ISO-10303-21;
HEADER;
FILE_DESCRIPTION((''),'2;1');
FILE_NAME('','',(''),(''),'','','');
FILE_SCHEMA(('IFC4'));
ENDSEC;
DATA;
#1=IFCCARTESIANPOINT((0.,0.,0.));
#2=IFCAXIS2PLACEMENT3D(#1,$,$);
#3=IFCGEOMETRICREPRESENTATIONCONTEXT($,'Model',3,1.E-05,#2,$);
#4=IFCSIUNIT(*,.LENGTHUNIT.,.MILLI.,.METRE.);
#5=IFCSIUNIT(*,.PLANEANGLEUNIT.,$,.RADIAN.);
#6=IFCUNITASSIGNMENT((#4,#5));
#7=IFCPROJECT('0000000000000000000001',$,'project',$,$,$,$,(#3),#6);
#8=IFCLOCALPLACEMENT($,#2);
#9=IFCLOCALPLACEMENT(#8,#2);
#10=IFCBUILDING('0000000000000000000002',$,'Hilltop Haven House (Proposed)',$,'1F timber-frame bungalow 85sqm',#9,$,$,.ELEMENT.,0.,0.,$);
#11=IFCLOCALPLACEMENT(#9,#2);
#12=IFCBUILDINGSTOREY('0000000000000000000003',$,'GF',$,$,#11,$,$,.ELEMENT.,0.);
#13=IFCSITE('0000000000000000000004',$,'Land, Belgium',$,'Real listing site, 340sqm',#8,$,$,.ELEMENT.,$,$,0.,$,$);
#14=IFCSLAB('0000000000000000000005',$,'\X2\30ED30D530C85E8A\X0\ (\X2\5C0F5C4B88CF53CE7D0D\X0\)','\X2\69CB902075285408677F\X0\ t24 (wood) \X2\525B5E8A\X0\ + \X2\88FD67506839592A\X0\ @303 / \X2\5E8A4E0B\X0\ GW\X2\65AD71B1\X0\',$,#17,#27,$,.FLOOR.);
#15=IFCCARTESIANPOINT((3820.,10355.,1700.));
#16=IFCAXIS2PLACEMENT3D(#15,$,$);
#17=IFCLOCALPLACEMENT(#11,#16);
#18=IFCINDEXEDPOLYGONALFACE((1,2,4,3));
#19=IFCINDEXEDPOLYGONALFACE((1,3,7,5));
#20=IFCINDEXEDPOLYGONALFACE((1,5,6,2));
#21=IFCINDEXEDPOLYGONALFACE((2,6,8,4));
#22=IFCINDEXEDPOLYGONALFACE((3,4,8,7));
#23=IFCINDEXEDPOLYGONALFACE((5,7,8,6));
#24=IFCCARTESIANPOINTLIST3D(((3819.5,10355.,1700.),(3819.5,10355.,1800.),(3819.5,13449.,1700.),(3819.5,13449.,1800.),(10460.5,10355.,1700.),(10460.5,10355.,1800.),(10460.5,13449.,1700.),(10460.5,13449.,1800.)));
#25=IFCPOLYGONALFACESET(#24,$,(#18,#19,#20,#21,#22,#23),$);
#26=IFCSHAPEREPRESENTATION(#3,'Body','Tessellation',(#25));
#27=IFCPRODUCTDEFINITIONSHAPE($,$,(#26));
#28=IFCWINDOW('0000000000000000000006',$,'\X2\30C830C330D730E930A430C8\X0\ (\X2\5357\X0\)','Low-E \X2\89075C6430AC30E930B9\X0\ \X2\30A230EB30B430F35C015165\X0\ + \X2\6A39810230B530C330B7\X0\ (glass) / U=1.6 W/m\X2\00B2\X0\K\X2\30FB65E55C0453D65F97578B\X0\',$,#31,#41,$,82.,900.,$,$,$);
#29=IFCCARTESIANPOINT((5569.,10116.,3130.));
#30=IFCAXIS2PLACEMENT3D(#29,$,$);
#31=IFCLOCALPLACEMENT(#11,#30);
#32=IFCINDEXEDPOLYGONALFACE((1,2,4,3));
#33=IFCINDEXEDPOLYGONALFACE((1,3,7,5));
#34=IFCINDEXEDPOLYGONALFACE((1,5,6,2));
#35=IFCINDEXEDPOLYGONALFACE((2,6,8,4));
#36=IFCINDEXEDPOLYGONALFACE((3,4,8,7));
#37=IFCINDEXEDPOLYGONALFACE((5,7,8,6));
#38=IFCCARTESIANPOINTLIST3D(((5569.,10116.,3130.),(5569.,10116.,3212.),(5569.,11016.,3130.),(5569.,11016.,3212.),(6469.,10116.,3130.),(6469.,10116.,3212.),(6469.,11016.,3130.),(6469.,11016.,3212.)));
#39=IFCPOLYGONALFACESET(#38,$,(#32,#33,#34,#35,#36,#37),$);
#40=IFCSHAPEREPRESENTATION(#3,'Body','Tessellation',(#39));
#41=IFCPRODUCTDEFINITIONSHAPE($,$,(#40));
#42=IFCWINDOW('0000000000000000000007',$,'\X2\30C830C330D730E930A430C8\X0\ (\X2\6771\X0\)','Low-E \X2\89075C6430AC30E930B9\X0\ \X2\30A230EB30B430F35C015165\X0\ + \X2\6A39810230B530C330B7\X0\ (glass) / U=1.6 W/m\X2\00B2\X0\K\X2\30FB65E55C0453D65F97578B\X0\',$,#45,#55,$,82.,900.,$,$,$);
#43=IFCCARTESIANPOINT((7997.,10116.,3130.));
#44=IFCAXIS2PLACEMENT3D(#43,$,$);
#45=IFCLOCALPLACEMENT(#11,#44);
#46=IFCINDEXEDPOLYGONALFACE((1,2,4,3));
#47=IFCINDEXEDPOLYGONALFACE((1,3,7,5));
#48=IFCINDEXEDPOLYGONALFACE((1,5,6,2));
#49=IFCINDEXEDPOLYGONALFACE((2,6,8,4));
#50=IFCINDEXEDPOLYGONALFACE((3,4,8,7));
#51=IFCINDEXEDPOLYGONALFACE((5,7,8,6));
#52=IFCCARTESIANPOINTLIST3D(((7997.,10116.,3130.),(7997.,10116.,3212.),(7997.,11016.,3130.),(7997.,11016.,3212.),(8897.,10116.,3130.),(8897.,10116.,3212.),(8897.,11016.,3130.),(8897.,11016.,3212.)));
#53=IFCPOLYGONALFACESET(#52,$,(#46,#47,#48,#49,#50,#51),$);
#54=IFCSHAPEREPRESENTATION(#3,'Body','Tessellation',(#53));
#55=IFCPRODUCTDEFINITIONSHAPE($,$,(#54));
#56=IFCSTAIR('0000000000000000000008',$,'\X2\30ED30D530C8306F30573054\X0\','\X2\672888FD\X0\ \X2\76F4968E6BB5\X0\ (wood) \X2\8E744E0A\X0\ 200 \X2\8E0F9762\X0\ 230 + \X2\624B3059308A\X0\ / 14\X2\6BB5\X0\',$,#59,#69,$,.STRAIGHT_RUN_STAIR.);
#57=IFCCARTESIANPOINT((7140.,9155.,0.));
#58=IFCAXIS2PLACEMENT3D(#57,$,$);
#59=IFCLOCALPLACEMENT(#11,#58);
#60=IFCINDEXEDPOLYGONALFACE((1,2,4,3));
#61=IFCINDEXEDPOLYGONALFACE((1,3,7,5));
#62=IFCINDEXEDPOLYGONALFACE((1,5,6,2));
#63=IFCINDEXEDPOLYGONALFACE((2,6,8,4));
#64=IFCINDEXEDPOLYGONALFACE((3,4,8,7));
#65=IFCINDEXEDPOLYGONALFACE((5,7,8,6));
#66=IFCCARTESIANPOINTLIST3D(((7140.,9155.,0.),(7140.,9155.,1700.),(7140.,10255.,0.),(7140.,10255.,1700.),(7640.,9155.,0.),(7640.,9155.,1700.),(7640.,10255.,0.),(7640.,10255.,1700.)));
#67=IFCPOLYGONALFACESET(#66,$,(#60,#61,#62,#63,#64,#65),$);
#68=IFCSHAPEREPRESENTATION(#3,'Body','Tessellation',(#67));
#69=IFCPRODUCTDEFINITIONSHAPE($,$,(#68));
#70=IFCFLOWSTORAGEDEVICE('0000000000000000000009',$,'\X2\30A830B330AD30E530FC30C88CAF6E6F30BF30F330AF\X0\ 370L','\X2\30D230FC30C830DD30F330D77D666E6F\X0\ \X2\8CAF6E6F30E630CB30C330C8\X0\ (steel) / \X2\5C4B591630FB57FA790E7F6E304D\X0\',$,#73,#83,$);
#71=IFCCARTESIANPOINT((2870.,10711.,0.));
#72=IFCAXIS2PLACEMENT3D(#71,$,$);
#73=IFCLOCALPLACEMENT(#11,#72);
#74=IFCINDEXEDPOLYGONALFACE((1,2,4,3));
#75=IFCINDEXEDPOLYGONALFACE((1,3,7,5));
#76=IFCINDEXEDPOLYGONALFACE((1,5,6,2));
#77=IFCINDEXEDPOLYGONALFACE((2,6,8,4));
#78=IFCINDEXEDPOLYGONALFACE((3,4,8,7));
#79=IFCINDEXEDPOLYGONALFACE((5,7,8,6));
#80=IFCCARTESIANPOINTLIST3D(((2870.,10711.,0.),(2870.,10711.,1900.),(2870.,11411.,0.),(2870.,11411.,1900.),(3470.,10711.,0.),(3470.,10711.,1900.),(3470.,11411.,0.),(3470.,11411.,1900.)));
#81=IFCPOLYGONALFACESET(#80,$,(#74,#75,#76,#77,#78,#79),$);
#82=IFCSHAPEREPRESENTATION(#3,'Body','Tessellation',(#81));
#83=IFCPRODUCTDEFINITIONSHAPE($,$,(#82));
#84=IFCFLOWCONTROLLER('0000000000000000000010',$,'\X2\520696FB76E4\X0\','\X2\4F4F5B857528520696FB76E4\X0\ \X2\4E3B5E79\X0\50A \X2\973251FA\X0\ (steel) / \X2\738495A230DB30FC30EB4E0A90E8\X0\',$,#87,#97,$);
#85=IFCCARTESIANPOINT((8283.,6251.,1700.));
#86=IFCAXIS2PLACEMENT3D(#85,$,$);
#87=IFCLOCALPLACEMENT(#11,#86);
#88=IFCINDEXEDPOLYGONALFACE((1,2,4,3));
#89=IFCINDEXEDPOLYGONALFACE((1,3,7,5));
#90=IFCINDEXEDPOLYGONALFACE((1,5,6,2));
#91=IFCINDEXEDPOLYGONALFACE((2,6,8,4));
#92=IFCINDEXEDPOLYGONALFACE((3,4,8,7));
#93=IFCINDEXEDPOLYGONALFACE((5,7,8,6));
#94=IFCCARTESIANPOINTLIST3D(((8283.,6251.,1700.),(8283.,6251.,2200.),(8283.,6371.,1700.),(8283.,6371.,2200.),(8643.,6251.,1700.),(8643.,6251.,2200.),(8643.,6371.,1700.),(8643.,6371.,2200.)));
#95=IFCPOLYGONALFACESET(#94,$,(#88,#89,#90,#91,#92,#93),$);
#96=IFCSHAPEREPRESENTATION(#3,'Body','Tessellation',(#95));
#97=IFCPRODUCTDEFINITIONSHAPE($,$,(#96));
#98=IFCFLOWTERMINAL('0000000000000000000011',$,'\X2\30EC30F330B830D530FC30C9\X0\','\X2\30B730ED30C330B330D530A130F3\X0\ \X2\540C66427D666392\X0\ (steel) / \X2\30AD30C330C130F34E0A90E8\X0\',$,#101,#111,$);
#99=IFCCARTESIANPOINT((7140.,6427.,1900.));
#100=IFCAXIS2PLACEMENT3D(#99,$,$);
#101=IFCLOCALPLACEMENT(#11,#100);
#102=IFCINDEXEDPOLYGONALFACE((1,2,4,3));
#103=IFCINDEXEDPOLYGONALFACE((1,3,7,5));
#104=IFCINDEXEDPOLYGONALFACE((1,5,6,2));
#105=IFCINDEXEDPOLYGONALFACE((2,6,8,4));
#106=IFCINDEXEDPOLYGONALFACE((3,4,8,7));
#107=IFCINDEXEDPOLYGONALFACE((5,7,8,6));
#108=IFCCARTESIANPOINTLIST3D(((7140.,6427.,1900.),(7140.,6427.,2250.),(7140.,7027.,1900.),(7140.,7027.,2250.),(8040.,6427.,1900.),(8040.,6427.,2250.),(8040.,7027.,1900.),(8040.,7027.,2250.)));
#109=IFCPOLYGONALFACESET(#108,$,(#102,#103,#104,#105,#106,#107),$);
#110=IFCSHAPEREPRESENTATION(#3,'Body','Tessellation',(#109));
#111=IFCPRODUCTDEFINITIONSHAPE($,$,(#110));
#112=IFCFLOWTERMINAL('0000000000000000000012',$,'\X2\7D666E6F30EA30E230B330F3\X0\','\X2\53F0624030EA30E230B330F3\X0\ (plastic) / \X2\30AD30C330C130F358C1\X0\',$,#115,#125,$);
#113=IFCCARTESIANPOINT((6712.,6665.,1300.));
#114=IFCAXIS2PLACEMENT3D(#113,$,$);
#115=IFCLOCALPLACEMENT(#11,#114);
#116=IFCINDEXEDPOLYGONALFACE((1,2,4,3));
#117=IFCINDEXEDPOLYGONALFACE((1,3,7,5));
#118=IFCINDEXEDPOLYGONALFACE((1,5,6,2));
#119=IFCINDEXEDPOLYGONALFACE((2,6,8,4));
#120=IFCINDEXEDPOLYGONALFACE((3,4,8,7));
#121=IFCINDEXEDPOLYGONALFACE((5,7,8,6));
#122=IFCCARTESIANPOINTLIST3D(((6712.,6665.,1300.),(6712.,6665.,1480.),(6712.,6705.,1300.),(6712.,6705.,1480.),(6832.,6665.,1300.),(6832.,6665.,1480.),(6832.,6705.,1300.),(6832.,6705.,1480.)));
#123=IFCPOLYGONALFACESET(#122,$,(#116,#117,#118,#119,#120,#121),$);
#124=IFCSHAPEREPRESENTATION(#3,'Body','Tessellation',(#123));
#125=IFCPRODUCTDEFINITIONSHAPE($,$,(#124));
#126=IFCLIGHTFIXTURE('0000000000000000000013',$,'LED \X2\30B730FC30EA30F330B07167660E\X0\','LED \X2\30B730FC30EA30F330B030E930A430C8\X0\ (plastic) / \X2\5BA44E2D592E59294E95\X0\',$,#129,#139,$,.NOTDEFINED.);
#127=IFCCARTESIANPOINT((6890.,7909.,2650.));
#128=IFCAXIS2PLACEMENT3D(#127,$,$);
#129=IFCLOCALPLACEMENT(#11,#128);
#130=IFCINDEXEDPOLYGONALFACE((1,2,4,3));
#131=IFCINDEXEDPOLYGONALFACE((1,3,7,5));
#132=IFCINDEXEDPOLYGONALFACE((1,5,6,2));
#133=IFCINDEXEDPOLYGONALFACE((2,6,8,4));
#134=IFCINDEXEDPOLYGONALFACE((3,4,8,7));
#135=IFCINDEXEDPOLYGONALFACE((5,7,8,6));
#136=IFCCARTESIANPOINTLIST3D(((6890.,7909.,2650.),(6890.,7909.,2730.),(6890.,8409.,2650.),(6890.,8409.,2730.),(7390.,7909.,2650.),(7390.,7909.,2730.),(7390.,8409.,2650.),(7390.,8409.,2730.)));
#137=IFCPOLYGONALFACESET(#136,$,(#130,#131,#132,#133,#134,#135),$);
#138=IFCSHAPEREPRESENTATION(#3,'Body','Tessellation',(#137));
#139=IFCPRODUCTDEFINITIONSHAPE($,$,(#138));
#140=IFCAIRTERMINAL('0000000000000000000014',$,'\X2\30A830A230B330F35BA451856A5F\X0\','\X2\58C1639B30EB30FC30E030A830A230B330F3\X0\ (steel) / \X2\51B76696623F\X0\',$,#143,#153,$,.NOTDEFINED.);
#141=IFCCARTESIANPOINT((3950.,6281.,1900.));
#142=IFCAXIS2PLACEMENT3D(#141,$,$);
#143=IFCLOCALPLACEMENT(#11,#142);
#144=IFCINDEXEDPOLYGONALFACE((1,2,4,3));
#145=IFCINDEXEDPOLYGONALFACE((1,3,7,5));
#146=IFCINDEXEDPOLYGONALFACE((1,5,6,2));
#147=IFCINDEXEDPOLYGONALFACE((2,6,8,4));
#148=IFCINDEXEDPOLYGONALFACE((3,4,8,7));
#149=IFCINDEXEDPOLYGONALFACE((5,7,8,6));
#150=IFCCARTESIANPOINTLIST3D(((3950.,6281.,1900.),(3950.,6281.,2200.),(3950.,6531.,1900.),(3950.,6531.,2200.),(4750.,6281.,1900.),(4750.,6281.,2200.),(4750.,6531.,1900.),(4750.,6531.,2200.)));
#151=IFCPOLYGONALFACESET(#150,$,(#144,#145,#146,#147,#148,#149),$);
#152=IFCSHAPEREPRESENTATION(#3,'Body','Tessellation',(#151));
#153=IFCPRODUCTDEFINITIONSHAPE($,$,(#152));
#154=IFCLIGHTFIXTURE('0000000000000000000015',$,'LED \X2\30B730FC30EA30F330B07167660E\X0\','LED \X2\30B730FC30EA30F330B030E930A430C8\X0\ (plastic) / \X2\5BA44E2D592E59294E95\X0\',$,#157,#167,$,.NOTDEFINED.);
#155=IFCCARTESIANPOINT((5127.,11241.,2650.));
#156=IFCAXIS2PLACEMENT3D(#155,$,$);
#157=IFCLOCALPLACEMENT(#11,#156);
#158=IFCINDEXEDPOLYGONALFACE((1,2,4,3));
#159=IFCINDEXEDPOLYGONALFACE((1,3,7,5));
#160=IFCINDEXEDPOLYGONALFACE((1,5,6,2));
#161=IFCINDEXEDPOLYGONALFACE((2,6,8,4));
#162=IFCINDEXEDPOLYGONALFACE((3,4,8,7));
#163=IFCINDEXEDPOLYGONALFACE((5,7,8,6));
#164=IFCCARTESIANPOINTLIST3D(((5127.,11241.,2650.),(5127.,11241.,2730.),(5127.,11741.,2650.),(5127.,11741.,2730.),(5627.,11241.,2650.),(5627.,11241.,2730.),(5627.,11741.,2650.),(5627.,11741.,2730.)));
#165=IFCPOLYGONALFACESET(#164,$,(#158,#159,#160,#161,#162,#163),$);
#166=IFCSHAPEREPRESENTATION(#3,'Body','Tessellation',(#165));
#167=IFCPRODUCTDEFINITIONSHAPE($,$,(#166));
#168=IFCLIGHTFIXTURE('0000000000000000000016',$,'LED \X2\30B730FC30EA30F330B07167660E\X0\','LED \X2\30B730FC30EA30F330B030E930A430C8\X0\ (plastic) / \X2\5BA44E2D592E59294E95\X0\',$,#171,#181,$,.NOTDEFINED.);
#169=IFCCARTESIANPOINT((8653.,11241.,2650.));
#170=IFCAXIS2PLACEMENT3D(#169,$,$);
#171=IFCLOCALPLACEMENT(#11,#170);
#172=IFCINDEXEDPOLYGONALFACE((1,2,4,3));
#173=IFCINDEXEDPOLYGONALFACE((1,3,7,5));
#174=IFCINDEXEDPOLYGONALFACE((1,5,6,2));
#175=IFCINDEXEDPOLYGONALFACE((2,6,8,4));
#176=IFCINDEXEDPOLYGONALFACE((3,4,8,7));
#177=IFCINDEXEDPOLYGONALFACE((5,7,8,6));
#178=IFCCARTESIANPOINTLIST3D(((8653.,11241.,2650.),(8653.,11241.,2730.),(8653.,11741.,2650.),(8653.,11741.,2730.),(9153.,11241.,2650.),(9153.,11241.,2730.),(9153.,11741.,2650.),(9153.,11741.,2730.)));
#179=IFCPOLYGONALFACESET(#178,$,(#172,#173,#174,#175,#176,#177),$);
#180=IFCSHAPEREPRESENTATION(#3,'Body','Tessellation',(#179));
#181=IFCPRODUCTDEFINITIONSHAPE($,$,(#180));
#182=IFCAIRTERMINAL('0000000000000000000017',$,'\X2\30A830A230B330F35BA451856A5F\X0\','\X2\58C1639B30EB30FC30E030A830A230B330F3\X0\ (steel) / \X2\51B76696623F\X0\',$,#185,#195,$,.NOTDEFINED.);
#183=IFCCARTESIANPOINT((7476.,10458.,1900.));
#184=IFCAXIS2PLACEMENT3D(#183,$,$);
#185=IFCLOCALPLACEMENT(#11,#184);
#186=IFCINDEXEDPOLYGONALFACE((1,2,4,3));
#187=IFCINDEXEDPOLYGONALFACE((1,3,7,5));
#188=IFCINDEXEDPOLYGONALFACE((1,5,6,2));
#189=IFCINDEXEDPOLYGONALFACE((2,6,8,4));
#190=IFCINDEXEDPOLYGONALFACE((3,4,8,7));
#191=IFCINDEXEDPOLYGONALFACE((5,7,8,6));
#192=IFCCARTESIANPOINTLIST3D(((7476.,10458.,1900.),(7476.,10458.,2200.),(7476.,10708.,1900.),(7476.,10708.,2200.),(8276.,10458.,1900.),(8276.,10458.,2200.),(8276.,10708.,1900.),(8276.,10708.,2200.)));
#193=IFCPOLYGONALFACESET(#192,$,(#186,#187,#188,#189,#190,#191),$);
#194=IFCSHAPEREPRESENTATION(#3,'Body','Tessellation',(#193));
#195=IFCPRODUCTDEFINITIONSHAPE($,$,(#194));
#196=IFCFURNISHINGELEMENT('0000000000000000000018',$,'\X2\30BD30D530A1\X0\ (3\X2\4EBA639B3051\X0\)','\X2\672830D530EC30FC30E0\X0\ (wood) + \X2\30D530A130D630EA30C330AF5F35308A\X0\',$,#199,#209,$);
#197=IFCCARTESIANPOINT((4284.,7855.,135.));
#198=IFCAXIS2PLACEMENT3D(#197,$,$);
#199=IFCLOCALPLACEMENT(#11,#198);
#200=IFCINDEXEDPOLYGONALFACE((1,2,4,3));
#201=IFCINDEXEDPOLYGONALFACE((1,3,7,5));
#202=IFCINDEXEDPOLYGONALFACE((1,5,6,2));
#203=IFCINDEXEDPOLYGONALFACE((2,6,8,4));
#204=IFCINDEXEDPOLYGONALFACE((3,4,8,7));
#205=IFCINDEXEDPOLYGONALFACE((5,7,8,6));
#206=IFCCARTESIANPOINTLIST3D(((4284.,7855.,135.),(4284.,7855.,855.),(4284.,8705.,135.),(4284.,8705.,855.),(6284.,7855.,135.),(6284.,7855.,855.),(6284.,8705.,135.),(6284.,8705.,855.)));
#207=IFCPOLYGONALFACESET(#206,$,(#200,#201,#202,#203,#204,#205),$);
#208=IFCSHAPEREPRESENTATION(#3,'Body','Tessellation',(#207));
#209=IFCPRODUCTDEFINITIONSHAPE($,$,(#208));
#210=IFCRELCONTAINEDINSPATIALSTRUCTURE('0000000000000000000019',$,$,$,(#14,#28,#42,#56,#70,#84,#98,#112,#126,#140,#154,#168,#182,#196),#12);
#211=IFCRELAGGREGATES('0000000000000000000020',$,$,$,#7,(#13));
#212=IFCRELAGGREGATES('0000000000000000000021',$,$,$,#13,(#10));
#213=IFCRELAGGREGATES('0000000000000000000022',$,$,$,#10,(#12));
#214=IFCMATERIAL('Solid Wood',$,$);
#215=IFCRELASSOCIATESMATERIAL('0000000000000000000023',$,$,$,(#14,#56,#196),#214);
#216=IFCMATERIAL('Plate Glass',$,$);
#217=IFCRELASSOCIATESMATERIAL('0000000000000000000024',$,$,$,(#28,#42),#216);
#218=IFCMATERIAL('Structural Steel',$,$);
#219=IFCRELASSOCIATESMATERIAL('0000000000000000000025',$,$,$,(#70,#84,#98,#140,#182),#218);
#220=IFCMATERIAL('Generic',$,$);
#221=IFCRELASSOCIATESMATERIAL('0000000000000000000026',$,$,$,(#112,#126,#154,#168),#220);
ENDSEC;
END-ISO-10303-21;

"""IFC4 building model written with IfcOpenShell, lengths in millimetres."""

from ifc_helpers import new_model, si_unit, frame, frame_2d, origin, place, context, project, spatial, rectangle, extrude, material, element, save


model = new_model("IFC4")

# Units and contexts
model_context = context("Model", 3, precision=1e-05, world=origin())
ifc_project = project(units=[si_unit("LENGTHUNIT", "METRE", prefix="MILLI"), si_unit("PLANEANGLEUNIT", "RADIAN")], contexts=[model_context])

# Site, building, storey
site_placement = place(None, origin())
site = spatial("IfcSite", under=ifc_project, at=site_placement, Name="Land, Belgium", ObjectType="Real listing site, 340sqm", CompositionType="ELEMENT", RefElevation=0.0)
building_placement = place(site_placement, origin())
building = spatial("IfcBuilding", under=site, at=building_placement, Name="Hilltop Haven House (Proposed)", ObjectType="1F timber-frame bungalow 85sqm", CompositionType="ELEMENT", ElevationOfRefHeight=0.0, ElevationOfTerrain=0.0)
storey_placement = place(building_placement, origin())
storey = spatial("IfcBuildingStorey", under=building, at=storey_placement, Name="GF", CompositionType="ELEMENT", Elevation=0.0)

# Shared definitions
ifc_material_1 = material(Name="Solid Wood")

# Slab
slab_placement = place(storey_placement, frame((3820.0, 10355.0, 1700.0)))
element("IfcSlab", 1, at=slab_placement, inside=storey, material=ifc_material_1, Name="ロフト床 (小屋裏収納)", Description="構造用合板 t24 (wood) 剛床 + 製材根太 @303 / 床下 GW断熱", PredefinedType="FLOOR", context=model_context, shape_type="SweptSolid", body=[
    extrude(rectangle(XDim=6641.0, YDim=3094.0, at=frame_2d((3320.0, 1547.0))), frame((3820.0, 10355.0, 1700.0)), (0.0, 0.0, 1.0), 100.0),
])

# Windows
ifc_material_2 = material(Name="Plate Glass")
window_1_placement = place(storey_placement, frame((5569.0, 10116.0, 3130.0)))
element("IfcWindow", 2, at=window_1_placement, inside=storey, material=ifc_material_2, Name="トップライト (南)", Description="Low-E 複層ガラス アルゴン封入 + 樹脂サッシ (glass) / U=1.6 W/m²K・日射取得型", OverallHeight=82.0, OverallWidth=900.0, context=model_context, shape_type="SweptSolid", body=[
    extrude(rectangle(XDim=900.0, YDim=900.0, at=frame_2d((450.0, 450.0))), frame((5569.0, 10116.0, 3130.0)), (0.0, 0.0, 1.0), 82.0),
])
window_2_placement = place(storey_placement, frame((7997.0, 10116.0, 3130.0)))
element("IfcWindow", 3, at=window_2_placement, inside=storey, material=ifc_material_2, Name="トップライト (東)", Description="Low-E 複層ガラス アルゴン封入 + 樹脂サッシ (glass) / U=1.6 W/m²K・日射取得型", OverallHeight=82.0, OverallWidth=900.0, context=model_context, shape_type="SweptSolid", body=[
    extrude(rectangle(XDim=900.0, YDim=900.0, at=frame_2d((450.0, 450.0))), frame((7997.0, 10116.0, 3130.0)), (0.0, 0.0, 1.0), 82.0),
])

# Stair
stair_placement = place(storey_placement, frame((7140.0, 9155.0, 0.0)))
element("IfcStair", 4, at=stair_placement, inside=storey, material=ifc_material_1, Name="ロフトはしご", Description="木製 直階段 (wood) 蹴上 200 踏面 230 + 手すり / 14段", PredefinedType="STRAIGHT_RUN_STAIR", context=model_context, shape_type="SweptSolid", body=[
    extrude(rectangle(XDim=500.0, YDim=1100.0, at=frame_2d((250.0, 550.0))), frame((7140.0, 9155.0, 0.0)), (0.0, 0.0, 1.0), 1700.0),
])

# Flow storage device
ifc_material_3 = material(Name="Structural Steel")
flow_storage_device_placement = place(storey_placement, frame((2870.0, 10711.0, 0.0)))
element("IfcFlowStorageDevice", 5, at=flow_storage_device_placement, inside=storey, material=ifc_material_3, Name="エコキュート貯湯タンク 370L", Description="ヒートポンプ給湯 貯湯ユニット (steel) / 屋外・基礎置き", context=model_context, shape_type="SweptSolid", body=[
    extrude(rectangle(XDim=600.0, YDim=700.0, at=frame_2d((300.0, 350.0))), frame((2870.0, 10711.0, 0.0)), (0.0, 0.0, 1.0), 1900.0),
])

# Flow controller
flow_controller_placement = place(storey_placement, frame((8283.0, 6251.0, 1700.0)))
element("IfcFlowController", 6, at=flow_controller_placement, inside=storey, material=ifc_material_3, Name="分電盤", Description="住宅用分電盤 主幹50A 露出 (steel) / 玄関ホール上部", context=model_context, shape_type="SweptSolid", body=[
    extrude(rectangle(XDim=360.0, YDim=120.0, at=frame_2d((180.0, 60.0))), frame((8283.0, 6251.0, 1700.0)), (0.0, 0.0, 1.0), 500.0),
])

# Flow terminals
flow_terminal_1_placement = place(storey_placement, frame((7140.0, 6427.0, 1900.0)))
element("IfcFlowTerminal", 7, at=flow_terminal_1_placement, inside=storey, material=ifc_material_3, Name="レンジフード", Description="シロッコファン 同時給排 (steel) / キッチン上部", context=model_context, shape_type="SweptSolid", body=[
    extrude(rectangle(XDim=900.0, YDim=600.0, at=frame_2d((450.0, 300.0))), frame((7140.0, 6427.0, 1900.0)), (0.0, 0.0, 1.0), 350.0),
])
ifc_material_4 = material(Name="Generic")
flow_terminal_2_placement = place(storey_placement, frame((6712.0, 6665.0, 1300.0)))
element("IfcFlowTerminal", 8, at=flow_terminal_2_placement, inside=storey, material=ifc_material_4, Name="給湯リモコン", Description="台所リモコン (plastic) / キッチン壁", context=model_context, shape_type="SweptSolid", body=[
    extrude(rectangle(XDim=120.0, YDim=40.0, at=frame_2d((60.0, 20.0))), frame((6712.0, 6665.0, 1300.0)), (0.0, 0.0, 1.0), 180.0),
])

# Light fixture
light_fixture_1_placement = place(storey_placement, frame((6890.0, 7909.0, 2650.0)))
element("IfcLightFixture", 9, at=light_fixture_1_placement, inside=storey, material=ifc_material_4, Name="LED シーリング照明", Description="LED シーリングライト (plastic) / 室中央天井", PredefinedType="NOTDEFINED", context=model_context, shape_type="SweptSolid", body=[
    extrude(rectangle(XDim=500.0, YDim=500.0, at=frame_2d((250.0, 250.0))), frame((6890.0, 7909.0, 2650.0)), (0.0, 0.0, 1.0), 80.0),
])

# Air terminal
air_terminal_1_placement = place(storey_placement, frame((3950.0, 6281.0, 1900.0)))
element("IfcAirTerminal", 10, at=air_terminal_1_placement, inside=storey, material=ifc_material_3, Name="エアコン室内機", Description="壁掛ルームエアコン (steel) / 冷暖房", PredefinedType="NOTDEFINED", context=model_context, shape_type="SweptSolid", body=[
    extrude(rectangle(XDim=800.0, YDim=250.0, at=frame_2d((400.0, 125.0))), frame((3950.0, 6281.0, 1900.0)), (0.0, 0.0, 1.0), 300.0),
])

# Light fixtures
light_fixture_2_placement = place(storey_placement, frame((5127.0, 11241.0, 2650.0)))
element("IfcLightFixture", 11, at=light_fixture_2_placement, inside=storey, material=ifc_material_4, Name="LED シーリング照明", Description="LED シーリングライト (plastic) / 室中央天井", PredefinedType="NOTDEFINED", context=model_context, shape_type="SweptSolid", body=[
    extrude(rectangle(XDim=500.0, YDim=500.0, at=frame_2d((250.0, 250.0))), frame((5127.0, 11241.0, 2650.0)), (0.0, 0.0, 1.0), 80.0),
])
light_fixture_3_placement = place(storey_placement, frame((8653.0, 11241.0, 2650.0)))
element("IfcLightFixture", 12, at=light_fixture_3_placement, inside=storey, material=ifc_material_4, Name="LED シーリング照明", Description="LED シーリングライト (plastic) / 室中央天井", PredefinedType="NOTDEFINED", context=model_context, shape_type="SweptSolid", body=[
    extrude(rectangle(XDim=500.0, YDim=500.0, at=frame_2d((250.0, 250.0))), frame((8653.0, 11241.0, 2650.0)), (0.0, 0.0, 1.0), 80.0),
])

# Air terminal
air_terminal_2_placement = place(storey_placement, frame((7476.0, 10458.0, 1900.0)))
element("IfcAirTerminal", 13, at=air_terminal_2_placement, inside=storey, material=ifc_material_3, Name="エアコン室内機", Description="壁掛ルームエアコン (steel) / 冷暖房", PredefinedType="NOTDEFINED", context=model_context, shape_type="SweptSolid", body=[
    extrude(rectangle(XDim=800.0, YDim=250.0, at=frame_2d((400.0, 125.0))), frame((7476.0, 10458.0, 1900.0)), (0.0, 0.0, 1.0), 300.0),
])

# Furnishing element
furnishing_1_placement = place(storey_placement, frame((4284.0, 7855.0, 135.0)))
element("IfcFurnishingElement", 14, at=furnishing_1_placement, inside=storey, material=ifc_material_1, Name="ソファ (3人掛け)", Description="木フレーム (wood) + ファブリック張り", context=model_context, shape_type="SweptSolid", body=[
    extrude(rectangle(XDim=2000.0, YDim=850.0, at=frame_2d((1000.0, 425.0))), frame((4284.0, 7855.0, 135.0)), (0.0, 0.0, 1.0), 720.0),
])

save(model, "model.ifc")
